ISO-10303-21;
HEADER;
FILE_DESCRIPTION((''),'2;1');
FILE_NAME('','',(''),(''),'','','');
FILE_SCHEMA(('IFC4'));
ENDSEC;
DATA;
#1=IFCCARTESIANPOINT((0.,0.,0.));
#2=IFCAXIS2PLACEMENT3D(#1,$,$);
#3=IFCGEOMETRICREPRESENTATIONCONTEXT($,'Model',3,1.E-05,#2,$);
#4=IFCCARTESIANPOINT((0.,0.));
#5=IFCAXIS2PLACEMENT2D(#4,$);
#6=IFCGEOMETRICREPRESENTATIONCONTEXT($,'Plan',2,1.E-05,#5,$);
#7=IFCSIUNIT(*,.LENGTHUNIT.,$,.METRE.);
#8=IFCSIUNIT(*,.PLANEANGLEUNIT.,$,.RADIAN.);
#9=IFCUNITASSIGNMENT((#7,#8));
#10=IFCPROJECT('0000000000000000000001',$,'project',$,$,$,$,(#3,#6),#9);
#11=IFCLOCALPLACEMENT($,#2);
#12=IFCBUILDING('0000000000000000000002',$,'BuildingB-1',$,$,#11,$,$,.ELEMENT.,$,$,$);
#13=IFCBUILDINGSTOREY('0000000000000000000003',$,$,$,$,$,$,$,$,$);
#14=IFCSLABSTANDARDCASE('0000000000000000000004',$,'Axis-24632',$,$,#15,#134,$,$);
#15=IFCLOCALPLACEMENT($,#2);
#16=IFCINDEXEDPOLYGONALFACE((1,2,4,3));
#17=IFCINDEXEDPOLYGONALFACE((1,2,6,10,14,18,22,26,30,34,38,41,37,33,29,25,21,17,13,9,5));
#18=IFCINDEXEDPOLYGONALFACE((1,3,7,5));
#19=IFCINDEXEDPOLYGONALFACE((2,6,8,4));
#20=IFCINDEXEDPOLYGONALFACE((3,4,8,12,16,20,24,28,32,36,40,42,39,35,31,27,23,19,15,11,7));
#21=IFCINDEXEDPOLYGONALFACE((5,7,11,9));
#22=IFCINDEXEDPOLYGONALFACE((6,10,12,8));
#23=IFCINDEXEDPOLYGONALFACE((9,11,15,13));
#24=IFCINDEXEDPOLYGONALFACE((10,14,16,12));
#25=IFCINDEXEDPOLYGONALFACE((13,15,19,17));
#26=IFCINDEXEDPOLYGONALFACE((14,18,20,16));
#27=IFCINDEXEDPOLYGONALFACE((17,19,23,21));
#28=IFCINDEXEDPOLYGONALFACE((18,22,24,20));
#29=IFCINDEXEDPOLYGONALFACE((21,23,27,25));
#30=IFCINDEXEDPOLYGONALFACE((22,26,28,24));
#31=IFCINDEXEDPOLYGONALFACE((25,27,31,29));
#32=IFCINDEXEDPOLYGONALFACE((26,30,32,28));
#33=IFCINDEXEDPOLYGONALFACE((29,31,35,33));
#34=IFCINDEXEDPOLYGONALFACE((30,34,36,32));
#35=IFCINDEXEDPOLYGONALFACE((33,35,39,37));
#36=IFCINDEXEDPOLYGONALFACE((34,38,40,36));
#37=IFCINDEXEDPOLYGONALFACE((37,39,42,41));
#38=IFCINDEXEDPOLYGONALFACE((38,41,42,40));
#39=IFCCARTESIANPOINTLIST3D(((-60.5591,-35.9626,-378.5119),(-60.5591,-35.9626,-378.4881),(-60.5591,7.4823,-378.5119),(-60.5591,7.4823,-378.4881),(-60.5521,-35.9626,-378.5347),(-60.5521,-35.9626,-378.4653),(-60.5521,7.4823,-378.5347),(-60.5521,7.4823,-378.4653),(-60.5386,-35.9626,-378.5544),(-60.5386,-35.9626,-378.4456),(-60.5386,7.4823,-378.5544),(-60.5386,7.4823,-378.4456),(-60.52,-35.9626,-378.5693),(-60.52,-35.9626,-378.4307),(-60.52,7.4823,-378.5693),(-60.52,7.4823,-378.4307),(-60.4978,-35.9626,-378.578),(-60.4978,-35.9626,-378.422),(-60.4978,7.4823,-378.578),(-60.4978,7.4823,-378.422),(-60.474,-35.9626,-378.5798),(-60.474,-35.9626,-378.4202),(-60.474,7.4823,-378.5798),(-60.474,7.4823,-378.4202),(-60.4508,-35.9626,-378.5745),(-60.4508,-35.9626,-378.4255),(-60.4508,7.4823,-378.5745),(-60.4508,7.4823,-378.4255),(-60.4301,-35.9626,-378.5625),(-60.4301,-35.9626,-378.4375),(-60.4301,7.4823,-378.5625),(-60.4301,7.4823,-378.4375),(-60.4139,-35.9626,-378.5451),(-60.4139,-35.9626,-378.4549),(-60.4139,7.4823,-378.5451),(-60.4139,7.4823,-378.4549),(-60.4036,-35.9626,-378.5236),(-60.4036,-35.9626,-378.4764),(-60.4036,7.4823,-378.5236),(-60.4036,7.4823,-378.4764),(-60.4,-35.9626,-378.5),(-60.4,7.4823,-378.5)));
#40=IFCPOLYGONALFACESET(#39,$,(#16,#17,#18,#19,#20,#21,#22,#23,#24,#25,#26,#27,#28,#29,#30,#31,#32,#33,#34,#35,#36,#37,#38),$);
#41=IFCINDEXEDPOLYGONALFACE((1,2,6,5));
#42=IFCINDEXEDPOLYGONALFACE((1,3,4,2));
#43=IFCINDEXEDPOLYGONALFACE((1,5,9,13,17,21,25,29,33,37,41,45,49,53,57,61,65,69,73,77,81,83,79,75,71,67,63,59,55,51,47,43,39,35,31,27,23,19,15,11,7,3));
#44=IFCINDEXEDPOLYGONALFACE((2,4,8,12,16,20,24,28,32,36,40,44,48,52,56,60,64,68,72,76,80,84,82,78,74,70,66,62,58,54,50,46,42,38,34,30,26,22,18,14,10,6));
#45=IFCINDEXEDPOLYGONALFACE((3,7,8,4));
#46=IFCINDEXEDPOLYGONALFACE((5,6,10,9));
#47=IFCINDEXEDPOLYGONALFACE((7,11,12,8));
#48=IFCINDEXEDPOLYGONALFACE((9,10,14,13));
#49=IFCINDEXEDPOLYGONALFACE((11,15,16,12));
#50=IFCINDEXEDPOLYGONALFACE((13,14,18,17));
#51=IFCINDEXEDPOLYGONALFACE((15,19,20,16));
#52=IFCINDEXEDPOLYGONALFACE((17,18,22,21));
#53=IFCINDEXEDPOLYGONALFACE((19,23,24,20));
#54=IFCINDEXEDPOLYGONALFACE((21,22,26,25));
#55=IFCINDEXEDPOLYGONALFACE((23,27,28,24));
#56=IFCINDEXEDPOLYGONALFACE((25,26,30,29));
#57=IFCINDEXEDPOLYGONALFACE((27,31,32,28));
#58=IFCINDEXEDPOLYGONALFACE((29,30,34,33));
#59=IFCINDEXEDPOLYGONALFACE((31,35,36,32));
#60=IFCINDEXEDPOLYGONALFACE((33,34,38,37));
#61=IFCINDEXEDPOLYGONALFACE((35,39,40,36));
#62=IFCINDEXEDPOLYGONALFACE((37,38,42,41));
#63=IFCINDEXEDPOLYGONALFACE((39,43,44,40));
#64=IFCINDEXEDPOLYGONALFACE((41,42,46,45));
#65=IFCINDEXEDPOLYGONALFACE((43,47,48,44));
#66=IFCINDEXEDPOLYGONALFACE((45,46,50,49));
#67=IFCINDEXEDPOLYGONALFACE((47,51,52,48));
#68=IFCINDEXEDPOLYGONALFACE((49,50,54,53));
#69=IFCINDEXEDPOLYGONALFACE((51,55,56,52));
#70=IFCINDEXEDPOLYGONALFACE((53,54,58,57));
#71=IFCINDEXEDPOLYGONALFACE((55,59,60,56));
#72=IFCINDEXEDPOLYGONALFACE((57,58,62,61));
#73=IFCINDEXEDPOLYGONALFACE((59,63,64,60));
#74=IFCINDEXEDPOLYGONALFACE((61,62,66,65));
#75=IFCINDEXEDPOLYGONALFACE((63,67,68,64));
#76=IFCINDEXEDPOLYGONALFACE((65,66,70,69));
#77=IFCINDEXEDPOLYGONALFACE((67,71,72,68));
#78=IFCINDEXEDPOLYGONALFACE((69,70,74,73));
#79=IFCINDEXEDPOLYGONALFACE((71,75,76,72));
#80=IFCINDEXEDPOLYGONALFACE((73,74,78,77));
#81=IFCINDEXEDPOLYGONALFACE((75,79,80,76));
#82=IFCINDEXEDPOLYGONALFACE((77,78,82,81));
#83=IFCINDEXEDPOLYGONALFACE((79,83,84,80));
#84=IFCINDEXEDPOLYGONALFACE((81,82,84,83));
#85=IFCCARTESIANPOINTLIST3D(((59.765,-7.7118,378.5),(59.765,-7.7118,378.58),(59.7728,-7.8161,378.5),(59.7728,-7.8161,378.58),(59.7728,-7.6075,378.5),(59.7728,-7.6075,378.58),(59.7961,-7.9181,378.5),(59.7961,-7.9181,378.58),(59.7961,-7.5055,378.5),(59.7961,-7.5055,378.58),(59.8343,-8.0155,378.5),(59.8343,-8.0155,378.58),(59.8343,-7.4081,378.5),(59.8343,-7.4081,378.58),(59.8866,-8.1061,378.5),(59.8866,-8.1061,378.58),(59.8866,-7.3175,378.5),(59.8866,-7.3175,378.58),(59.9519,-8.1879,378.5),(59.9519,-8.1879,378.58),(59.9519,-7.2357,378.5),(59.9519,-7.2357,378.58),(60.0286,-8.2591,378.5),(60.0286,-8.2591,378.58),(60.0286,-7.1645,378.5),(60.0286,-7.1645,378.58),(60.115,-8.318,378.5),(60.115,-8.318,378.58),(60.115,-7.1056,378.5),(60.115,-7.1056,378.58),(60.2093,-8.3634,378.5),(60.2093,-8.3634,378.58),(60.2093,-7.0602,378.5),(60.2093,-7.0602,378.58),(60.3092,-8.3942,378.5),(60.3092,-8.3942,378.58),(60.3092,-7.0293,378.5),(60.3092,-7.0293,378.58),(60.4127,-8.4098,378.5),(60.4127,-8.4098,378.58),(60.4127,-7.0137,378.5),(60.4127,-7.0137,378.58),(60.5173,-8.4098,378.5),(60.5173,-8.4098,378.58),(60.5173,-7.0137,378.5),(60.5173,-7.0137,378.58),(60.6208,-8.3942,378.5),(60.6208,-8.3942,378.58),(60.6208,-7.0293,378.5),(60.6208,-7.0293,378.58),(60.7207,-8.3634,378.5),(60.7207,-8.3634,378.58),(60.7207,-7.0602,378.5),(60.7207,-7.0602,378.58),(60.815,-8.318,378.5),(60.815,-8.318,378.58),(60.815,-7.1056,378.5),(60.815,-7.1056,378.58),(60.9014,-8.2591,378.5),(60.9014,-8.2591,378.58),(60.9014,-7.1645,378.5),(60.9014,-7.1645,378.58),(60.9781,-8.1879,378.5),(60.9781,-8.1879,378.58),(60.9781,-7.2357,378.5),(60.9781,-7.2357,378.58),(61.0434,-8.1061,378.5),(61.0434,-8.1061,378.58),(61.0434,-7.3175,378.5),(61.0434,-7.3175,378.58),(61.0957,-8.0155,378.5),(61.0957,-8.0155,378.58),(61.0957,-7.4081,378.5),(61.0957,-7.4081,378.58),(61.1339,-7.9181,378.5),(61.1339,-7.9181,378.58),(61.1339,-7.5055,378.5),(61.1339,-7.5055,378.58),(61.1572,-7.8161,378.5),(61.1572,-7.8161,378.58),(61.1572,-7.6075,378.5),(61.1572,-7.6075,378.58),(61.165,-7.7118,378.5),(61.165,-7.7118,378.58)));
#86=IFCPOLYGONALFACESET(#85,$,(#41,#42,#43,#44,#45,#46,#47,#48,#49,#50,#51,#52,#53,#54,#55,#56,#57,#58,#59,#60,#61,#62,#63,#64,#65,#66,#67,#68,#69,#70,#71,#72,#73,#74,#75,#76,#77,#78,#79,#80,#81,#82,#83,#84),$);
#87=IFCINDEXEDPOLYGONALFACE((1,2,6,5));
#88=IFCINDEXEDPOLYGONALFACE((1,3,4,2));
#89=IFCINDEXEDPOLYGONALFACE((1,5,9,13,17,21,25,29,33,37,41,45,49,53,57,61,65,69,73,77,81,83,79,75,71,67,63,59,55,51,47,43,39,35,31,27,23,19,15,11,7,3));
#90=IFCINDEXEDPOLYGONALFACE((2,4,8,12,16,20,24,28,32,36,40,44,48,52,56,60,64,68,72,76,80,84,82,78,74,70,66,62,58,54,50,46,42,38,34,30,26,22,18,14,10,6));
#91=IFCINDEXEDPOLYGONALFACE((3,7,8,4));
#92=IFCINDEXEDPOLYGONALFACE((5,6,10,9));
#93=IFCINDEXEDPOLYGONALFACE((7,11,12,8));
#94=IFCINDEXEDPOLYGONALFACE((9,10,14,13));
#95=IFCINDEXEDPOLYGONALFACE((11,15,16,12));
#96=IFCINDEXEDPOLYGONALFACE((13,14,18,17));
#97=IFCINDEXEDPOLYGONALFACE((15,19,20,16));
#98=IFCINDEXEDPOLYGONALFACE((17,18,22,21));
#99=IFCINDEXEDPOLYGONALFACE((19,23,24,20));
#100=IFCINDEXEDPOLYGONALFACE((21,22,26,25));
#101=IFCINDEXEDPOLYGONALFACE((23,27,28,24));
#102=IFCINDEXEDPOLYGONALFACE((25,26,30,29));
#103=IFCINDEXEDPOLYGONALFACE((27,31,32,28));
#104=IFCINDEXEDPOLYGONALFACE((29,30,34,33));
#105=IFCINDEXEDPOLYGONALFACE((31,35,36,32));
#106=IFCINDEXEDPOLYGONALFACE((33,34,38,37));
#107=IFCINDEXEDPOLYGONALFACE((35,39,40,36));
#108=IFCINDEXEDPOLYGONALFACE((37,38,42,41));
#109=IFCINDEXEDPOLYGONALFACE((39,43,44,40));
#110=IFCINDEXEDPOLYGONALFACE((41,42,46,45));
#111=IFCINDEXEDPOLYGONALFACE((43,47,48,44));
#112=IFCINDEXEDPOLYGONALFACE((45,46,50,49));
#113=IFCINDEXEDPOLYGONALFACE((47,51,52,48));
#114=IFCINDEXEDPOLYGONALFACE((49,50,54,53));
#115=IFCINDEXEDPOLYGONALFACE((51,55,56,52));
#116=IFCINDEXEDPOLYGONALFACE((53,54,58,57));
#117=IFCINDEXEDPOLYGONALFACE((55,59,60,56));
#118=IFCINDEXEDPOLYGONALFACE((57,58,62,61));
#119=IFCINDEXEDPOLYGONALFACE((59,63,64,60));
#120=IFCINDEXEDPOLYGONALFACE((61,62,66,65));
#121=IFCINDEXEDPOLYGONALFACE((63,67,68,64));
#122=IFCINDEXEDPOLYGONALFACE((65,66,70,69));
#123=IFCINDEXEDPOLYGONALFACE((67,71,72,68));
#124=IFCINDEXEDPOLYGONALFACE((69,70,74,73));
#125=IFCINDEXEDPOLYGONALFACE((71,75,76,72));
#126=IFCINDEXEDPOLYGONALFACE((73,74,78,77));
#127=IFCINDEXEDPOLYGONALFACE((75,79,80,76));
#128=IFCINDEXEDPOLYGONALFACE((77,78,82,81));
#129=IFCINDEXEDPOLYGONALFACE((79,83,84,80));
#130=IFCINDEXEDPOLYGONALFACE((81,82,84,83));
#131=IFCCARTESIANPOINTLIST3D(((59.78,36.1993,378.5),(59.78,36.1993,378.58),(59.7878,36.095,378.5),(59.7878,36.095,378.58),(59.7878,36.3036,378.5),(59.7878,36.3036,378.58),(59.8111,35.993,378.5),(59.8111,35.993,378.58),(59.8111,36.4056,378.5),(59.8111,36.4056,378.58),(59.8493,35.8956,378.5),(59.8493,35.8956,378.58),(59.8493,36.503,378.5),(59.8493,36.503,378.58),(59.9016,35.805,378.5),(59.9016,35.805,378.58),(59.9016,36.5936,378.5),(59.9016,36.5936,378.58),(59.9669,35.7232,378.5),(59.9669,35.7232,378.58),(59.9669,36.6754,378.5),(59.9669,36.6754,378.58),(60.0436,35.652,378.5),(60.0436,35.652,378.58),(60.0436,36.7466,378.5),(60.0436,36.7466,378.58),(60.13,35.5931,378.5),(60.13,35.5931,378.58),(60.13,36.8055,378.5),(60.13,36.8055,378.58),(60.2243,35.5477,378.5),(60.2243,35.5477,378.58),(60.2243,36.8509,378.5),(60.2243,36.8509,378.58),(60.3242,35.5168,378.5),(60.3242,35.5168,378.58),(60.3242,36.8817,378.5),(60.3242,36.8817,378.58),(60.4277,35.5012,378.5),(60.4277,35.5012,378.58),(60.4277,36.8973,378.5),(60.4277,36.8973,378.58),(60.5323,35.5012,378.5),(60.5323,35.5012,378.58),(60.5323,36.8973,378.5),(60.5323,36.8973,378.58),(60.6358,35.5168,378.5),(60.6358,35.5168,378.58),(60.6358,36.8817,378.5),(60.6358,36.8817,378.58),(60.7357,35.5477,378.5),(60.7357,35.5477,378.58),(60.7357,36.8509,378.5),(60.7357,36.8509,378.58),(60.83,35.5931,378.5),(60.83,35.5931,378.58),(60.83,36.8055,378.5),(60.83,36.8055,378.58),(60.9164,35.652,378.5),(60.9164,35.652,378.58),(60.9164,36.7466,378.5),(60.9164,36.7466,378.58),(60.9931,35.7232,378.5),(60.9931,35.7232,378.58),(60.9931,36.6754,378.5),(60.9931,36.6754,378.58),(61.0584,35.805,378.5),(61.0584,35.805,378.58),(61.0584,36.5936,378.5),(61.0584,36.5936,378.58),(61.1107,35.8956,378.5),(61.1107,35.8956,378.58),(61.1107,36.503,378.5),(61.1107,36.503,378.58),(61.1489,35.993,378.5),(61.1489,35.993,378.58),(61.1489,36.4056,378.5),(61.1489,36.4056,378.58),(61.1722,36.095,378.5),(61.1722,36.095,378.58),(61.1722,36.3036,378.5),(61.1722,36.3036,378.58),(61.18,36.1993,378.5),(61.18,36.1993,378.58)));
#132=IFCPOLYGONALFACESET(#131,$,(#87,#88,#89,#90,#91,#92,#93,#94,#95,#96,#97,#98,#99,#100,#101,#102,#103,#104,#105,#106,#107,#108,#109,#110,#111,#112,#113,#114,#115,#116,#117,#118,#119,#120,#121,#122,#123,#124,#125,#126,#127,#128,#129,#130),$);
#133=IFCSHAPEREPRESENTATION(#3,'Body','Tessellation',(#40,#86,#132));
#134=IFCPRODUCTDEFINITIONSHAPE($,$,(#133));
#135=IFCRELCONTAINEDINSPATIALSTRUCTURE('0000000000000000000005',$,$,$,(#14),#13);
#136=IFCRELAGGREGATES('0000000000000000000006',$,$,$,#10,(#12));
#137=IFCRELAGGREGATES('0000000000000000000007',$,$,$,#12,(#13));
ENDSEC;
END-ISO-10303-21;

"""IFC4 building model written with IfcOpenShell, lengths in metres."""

from ifc_helpers import new_model, entity, si_unit, frame, origin, origin_2d, place, context, project, spatial, circle, extrude, element, save


model = new_model("IFC4")

# Units and contexts
model_context = context("Model", 3, precision=1e-05, world=origin())
plan_context = context("Plan", 2, precision=1e-05, world=origin_2d())
ifc_project = project(units=[si_unit("LENGTHUNIT", "METRE"), si_unit("PLANEANGLEUNIT", "RADIAN")], contexts=[model_context, plan_context])

# Building, storey
building_placement = place(None, origin())
building = spatial("IfcBuilding", under=ifc_project, at=building_placement, Name="BuildingB-1", CompositionType="ELEMENT")
storey = spatial("IfcBuildingStorey", under=building)

# Slab
element("IfcSlabStandardCase", 1, inside=storey, Name="Axis-24632", context=model_context, shape_type="AdvancedSweptSolid", body=[
    entity("IfcSurfaceCurveSweptAreaSolid", entity("IfcCircleProfileDef", "AREA", None, None, 0.08), None, entity("IfcPolyline", [entity("IfcCartesianPoint", [60.48, -7.4823, 378.5]), entity("IfcCartesianPoint", [60.48, 35.9626, 378.5])]), None, None, entity("IfcPlane", entity("IfcAxis2Placement3D", entity("IfcCartesianPoint", [60.48, -7.4823, 378.5]), entity("IfcDirection", [0.0, 0.0, 1.0]), entity("IfcDirection", [1.0, 0.0, 0.0])))),
    extrude(circle(Radius=0.7), frame((60.465, -7.7118, 378.5)), (0.0, 0.0, 1.0), 0.08),
    extrude(circle(Radius=0.7), frame((60.48, 36.1993, 378.5)), (0.0, 0.0, 1.0), 0.08),
])

save(model, "model.ifc")
